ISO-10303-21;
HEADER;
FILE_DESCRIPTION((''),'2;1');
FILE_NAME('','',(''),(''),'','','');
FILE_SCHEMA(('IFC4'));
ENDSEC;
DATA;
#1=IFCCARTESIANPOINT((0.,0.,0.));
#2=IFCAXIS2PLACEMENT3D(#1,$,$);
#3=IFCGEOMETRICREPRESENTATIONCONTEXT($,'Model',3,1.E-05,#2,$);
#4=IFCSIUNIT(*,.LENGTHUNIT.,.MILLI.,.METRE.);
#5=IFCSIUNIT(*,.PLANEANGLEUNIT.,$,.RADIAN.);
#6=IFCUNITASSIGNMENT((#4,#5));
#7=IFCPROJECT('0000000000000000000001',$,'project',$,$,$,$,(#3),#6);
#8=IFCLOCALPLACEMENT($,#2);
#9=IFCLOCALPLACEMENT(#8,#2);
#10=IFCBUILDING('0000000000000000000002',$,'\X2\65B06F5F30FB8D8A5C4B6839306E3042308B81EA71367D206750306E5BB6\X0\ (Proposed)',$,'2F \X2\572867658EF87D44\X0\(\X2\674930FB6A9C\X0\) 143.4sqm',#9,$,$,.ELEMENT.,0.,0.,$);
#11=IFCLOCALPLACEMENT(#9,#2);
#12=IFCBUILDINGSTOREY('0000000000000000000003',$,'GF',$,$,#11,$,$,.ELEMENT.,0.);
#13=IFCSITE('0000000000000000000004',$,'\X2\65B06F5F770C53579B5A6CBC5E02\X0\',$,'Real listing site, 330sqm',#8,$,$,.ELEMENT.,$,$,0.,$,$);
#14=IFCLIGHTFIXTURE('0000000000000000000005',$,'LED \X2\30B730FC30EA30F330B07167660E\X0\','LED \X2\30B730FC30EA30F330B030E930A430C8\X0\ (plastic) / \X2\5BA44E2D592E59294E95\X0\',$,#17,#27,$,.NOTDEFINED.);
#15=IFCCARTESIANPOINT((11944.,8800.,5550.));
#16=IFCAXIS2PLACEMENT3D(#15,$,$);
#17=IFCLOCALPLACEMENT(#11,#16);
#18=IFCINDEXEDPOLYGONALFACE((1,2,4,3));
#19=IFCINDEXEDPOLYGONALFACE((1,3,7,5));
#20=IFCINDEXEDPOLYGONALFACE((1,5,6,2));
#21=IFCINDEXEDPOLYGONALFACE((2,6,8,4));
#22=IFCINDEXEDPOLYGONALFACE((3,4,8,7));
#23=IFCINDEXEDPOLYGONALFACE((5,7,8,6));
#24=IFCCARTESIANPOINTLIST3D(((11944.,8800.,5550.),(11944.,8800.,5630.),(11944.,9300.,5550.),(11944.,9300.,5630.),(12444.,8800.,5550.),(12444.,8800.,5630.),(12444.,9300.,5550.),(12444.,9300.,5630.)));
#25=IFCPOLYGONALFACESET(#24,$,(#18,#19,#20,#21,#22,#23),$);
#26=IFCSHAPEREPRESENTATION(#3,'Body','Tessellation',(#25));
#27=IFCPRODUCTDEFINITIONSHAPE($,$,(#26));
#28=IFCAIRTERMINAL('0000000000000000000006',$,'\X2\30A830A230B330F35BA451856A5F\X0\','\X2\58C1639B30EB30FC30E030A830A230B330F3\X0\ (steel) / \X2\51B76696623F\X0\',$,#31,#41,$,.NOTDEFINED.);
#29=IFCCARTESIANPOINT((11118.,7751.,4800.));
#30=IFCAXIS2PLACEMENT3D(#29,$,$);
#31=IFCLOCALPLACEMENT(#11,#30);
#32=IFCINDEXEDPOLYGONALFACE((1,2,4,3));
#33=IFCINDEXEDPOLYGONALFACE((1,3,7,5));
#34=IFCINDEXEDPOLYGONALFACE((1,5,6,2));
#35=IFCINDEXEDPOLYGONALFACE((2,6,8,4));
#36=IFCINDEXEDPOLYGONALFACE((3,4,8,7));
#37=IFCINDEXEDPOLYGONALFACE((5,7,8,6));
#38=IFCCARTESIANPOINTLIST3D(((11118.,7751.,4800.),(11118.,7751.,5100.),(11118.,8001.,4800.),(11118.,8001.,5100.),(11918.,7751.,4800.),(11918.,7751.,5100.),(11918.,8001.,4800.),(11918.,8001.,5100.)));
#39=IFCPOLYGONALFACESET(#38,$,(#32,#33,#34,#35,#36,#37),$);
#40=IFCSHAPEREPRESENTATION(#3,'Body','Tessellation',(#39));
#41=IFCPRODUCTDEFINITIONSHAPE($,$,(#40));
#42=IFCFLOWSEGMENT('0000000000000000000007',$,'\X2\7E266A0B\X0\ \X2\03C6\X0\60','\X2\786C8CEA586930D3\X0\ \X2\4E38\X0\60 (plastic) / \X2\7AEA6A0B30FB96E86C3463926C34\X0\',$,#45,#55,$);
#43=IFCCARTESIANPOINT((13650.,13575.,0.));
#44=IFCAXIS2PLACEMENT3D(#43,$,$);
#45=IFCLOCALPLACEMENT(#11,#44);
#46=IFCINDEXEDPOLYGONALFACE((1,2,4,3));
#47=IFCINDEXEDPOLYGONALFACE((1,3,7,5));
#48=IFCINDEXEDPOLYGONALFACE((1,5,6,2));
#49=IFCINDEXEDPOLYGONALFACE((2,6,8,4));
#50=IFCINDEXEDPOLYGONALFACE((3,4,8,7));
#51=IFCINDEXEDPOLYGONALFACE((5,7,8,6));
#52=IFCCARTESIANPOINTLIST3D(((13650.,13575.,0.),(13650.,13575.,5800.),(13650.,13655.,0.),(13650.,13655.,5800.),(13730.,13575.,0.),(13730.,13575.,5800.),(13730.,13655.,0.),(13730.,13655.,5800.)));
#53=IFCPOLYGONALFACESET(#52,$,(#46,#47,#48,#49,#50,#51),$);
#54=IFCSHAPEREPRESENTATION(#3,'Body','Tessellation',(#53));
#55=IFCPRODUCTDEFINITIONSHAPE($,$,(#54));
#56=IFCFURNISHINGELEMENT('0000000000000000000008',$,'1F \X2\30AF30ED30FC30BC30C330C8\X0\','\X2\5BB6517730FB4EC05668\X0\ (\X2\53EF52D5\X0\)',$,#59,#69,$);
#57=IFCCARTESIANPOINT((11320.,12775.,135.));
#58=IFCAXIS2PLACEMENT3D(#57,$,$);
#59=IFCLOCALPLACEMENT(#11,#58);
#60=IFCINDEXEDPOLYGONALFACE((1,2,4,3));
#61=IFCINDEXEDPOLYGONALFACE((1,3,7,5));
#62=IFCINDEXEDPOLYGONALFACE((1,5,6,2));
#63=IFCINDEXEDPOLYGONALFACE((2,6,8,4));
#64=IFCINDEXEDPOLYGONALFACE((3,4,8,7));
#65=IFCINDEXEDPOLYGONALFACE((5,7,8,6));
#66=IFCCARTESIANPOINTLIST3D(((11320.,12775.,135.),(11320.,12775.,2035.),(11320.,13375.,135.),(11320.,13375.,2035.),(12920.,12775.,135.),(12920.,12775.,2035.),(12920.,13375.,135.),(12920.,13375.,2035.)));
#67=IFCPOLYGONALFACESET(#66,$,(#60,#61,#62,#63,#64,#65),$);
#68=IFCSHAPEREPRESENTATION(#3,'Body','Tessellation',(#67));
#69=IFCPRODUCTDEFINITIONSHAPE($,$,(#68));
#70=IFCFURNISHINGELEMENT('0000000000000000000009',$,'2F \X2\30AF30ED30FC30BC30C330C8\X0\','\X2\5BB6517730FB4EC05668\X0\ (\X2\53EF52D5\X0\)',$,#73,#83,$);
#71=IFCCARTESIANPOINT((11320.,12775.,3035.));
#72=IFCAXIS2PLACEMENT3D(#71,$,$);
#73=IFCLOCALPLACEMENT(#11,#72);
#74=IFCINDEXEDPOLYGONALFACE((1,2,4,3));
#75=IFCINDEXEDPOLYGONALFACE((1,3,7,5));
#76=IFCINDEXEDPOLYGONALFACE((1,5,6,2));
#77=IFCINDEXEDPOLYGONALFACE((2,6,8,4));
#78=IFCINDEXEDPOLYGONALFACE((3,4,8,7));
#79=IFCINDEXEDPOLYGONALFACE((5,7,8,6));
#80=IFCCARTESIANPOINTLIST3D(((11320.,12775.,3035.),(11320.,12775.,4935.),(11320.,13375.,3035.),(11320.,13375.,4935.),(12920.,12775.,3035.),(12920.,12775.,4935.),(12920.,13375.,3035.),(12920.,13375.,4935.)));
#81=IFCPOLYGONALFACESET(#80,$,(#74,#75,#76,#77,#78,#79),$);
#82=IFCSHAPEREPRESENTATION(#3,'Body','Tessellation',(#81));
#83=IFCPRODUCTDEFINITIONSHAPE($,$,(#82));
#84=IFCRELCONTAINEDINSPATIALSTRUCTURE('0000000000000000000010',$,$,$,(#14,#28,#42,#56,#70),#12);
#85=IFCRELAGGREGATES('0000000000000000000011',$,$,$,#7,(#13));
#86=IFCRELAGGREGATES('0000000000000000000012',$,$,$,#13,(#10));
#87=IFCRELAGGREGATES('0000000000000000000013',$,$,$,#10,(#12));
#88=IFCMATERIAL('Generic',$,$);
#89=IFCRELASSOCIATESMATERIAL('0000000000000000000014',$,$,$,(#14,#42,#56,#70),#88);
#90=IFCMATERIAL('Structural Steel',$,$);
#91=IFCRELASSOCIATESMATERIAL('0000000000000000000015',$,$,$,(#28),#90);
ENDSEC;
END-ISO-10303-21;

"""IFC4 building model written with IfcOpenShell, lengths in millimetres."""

from ifc_helpers import new_model, si_unit, frame, frame_2d, origin, place, context, project, spatial, rectangle, extrude, material, element, save


model = new_model("IFC4")

# Units and contexts
model_context = context("Model", 3, precision=1e-05, world=origin())
ifc_project = project(units=[si_unit("LENGTHUNIT", "METRE", prefix="MILLI"), si_unit("PLANEANGLEUNIT", "RADIAN")], contexts=[model_context])

# Site, building, storey
site_placement = place(None, origin())
site = spatial("IfcSite", under=ifc_project, at=site_placement, Name="新潟県南魚沼市", ObjectType="Real listing site, 330sqm", CompositionType="ELEMENT", RefElevation=0.0)
building_placement = place(site_placement, origin())
building = spatial("IfcBuilding", under=site, at=building_placement, Name="新潟・越屋根のある自然素材の家 (Proposed)", ObjectType="2F 在来軸組(杉・檜) 143.4sqm", CompositionType="ELEMENT", ElevationOfRefHeight=0.0, ElevationOfTerrain=0.0)
storey_placement = place(building_placement, origin())
storey = spatial("IfcBuildingStorey", under=building, at=storey_placement, Name="GF", CompositionType="ELEMENT", Elevation=0.0)

# Shared definitions
ifc_material_1 = material(Name="Generic")

# Light fixture
light_fixture_1_placement = place(storey_placement, frame((11944.0, 8800.0, 5550.0)))
element("IfcLightFixture", 1, at=light_fixture_1_placement, inside=storey, material=ifc_material_1, Name="LED シーリング照明", Description="LED シーリングライト (plastic) / 室中央天井", PredefinedType="NOTDEFINED", context=model_context, shape_type="SweptSolid", body=[
    extrude(rectangle(XDim=500.0, YDim=500.0, at=frame_2d((250.0, 250.0))), frame((11944.0, 8800.0, 5550.0)), (0.0, 0.0, 1.0), 80.0),
])

# Air terminal
ifc_material_2 = material(Name="Structural Steel")
air_terminal_placement = place(storey_placement, frame((11118.0, 7751.0, 4800.0)))
element("IfcAirTerminal", 2, at=air_terminal_placement, inside=storey, material=ifc_material_2, Name="エアコン室内機", Description="壁掛ルームエアコン (steel) / 冷暖房", PredefinedType="NOTDEFINED", context=model_context, shape_type="SweptSolid", body=[
    extrude(rectangle(XDim=800.0, YDim=250.0, at=frame_2d((400.0, 125.0))), frame((11118.0, 7751.0, 4800.0)), (0.0, 0.0, 1.0), 300.0),
])

# Flow segment
flow_segment_placement = place(storey_placement, frame((13650.0, 13575.0, 0.0)))
element("IfcFlowSegment", 3, at=flow_segment_placement, inside=storey, material=ifc_material_1, Name="縦樋 φ60", Description="硬質塩ビ 丸60 (plastic) / 竪樋・雨水排水", context=model_context, shape_type="SweptSolid", body=[
    extrude(rectangle(XDim=80.0, YDim=80.0, at=frame_2d((40.0, 40.0))), frame((13650.0, 13575.0, 0.0)), (0.0, 0.0, 1.0), 5800.0),
])

# Furnishing elements
furnishing_1_placement = place(storey_placement, frame((11320.0, 12775.0, 135.0)))
element("IfcFurnishingElement", 4, at=furnishing_1_placement, inside=storey, material=ifc_material_1, Name="1F クローゼット", Description="家具・什器 (可動)", context=model_context, shape_type="SweptSolid", body=[
    extrude(rectangle(XDim=1600.0, YDim=600.0, at=frame_2d((800.0, 300.0))), frame((11320.0, 12775.0, 135.0)), (0.0, 0.0, 1.0), 1900.0),
])
furnishing_2_placement = place(storey_placement, frame((11320.0, 12775.0, 3035.0)))
element("IfcFurnishingElement", 5, at=furnishing_2_placement, inside=storey, material=ifc_material_1, Name="2F クローゼット", Description="家具・什器 (可動)", context=model_context, shape_type="SweptSolid", body=[
    extrude(rectangle(XDim=1600.0, YDim=600.0, at=frame_2d((800.0, 300.0))), frame((11320.0, 12775.0, 3035.0)), (0.0, 0.0, 1.0), 1900.0),
])

save(model, "model.ifc")
